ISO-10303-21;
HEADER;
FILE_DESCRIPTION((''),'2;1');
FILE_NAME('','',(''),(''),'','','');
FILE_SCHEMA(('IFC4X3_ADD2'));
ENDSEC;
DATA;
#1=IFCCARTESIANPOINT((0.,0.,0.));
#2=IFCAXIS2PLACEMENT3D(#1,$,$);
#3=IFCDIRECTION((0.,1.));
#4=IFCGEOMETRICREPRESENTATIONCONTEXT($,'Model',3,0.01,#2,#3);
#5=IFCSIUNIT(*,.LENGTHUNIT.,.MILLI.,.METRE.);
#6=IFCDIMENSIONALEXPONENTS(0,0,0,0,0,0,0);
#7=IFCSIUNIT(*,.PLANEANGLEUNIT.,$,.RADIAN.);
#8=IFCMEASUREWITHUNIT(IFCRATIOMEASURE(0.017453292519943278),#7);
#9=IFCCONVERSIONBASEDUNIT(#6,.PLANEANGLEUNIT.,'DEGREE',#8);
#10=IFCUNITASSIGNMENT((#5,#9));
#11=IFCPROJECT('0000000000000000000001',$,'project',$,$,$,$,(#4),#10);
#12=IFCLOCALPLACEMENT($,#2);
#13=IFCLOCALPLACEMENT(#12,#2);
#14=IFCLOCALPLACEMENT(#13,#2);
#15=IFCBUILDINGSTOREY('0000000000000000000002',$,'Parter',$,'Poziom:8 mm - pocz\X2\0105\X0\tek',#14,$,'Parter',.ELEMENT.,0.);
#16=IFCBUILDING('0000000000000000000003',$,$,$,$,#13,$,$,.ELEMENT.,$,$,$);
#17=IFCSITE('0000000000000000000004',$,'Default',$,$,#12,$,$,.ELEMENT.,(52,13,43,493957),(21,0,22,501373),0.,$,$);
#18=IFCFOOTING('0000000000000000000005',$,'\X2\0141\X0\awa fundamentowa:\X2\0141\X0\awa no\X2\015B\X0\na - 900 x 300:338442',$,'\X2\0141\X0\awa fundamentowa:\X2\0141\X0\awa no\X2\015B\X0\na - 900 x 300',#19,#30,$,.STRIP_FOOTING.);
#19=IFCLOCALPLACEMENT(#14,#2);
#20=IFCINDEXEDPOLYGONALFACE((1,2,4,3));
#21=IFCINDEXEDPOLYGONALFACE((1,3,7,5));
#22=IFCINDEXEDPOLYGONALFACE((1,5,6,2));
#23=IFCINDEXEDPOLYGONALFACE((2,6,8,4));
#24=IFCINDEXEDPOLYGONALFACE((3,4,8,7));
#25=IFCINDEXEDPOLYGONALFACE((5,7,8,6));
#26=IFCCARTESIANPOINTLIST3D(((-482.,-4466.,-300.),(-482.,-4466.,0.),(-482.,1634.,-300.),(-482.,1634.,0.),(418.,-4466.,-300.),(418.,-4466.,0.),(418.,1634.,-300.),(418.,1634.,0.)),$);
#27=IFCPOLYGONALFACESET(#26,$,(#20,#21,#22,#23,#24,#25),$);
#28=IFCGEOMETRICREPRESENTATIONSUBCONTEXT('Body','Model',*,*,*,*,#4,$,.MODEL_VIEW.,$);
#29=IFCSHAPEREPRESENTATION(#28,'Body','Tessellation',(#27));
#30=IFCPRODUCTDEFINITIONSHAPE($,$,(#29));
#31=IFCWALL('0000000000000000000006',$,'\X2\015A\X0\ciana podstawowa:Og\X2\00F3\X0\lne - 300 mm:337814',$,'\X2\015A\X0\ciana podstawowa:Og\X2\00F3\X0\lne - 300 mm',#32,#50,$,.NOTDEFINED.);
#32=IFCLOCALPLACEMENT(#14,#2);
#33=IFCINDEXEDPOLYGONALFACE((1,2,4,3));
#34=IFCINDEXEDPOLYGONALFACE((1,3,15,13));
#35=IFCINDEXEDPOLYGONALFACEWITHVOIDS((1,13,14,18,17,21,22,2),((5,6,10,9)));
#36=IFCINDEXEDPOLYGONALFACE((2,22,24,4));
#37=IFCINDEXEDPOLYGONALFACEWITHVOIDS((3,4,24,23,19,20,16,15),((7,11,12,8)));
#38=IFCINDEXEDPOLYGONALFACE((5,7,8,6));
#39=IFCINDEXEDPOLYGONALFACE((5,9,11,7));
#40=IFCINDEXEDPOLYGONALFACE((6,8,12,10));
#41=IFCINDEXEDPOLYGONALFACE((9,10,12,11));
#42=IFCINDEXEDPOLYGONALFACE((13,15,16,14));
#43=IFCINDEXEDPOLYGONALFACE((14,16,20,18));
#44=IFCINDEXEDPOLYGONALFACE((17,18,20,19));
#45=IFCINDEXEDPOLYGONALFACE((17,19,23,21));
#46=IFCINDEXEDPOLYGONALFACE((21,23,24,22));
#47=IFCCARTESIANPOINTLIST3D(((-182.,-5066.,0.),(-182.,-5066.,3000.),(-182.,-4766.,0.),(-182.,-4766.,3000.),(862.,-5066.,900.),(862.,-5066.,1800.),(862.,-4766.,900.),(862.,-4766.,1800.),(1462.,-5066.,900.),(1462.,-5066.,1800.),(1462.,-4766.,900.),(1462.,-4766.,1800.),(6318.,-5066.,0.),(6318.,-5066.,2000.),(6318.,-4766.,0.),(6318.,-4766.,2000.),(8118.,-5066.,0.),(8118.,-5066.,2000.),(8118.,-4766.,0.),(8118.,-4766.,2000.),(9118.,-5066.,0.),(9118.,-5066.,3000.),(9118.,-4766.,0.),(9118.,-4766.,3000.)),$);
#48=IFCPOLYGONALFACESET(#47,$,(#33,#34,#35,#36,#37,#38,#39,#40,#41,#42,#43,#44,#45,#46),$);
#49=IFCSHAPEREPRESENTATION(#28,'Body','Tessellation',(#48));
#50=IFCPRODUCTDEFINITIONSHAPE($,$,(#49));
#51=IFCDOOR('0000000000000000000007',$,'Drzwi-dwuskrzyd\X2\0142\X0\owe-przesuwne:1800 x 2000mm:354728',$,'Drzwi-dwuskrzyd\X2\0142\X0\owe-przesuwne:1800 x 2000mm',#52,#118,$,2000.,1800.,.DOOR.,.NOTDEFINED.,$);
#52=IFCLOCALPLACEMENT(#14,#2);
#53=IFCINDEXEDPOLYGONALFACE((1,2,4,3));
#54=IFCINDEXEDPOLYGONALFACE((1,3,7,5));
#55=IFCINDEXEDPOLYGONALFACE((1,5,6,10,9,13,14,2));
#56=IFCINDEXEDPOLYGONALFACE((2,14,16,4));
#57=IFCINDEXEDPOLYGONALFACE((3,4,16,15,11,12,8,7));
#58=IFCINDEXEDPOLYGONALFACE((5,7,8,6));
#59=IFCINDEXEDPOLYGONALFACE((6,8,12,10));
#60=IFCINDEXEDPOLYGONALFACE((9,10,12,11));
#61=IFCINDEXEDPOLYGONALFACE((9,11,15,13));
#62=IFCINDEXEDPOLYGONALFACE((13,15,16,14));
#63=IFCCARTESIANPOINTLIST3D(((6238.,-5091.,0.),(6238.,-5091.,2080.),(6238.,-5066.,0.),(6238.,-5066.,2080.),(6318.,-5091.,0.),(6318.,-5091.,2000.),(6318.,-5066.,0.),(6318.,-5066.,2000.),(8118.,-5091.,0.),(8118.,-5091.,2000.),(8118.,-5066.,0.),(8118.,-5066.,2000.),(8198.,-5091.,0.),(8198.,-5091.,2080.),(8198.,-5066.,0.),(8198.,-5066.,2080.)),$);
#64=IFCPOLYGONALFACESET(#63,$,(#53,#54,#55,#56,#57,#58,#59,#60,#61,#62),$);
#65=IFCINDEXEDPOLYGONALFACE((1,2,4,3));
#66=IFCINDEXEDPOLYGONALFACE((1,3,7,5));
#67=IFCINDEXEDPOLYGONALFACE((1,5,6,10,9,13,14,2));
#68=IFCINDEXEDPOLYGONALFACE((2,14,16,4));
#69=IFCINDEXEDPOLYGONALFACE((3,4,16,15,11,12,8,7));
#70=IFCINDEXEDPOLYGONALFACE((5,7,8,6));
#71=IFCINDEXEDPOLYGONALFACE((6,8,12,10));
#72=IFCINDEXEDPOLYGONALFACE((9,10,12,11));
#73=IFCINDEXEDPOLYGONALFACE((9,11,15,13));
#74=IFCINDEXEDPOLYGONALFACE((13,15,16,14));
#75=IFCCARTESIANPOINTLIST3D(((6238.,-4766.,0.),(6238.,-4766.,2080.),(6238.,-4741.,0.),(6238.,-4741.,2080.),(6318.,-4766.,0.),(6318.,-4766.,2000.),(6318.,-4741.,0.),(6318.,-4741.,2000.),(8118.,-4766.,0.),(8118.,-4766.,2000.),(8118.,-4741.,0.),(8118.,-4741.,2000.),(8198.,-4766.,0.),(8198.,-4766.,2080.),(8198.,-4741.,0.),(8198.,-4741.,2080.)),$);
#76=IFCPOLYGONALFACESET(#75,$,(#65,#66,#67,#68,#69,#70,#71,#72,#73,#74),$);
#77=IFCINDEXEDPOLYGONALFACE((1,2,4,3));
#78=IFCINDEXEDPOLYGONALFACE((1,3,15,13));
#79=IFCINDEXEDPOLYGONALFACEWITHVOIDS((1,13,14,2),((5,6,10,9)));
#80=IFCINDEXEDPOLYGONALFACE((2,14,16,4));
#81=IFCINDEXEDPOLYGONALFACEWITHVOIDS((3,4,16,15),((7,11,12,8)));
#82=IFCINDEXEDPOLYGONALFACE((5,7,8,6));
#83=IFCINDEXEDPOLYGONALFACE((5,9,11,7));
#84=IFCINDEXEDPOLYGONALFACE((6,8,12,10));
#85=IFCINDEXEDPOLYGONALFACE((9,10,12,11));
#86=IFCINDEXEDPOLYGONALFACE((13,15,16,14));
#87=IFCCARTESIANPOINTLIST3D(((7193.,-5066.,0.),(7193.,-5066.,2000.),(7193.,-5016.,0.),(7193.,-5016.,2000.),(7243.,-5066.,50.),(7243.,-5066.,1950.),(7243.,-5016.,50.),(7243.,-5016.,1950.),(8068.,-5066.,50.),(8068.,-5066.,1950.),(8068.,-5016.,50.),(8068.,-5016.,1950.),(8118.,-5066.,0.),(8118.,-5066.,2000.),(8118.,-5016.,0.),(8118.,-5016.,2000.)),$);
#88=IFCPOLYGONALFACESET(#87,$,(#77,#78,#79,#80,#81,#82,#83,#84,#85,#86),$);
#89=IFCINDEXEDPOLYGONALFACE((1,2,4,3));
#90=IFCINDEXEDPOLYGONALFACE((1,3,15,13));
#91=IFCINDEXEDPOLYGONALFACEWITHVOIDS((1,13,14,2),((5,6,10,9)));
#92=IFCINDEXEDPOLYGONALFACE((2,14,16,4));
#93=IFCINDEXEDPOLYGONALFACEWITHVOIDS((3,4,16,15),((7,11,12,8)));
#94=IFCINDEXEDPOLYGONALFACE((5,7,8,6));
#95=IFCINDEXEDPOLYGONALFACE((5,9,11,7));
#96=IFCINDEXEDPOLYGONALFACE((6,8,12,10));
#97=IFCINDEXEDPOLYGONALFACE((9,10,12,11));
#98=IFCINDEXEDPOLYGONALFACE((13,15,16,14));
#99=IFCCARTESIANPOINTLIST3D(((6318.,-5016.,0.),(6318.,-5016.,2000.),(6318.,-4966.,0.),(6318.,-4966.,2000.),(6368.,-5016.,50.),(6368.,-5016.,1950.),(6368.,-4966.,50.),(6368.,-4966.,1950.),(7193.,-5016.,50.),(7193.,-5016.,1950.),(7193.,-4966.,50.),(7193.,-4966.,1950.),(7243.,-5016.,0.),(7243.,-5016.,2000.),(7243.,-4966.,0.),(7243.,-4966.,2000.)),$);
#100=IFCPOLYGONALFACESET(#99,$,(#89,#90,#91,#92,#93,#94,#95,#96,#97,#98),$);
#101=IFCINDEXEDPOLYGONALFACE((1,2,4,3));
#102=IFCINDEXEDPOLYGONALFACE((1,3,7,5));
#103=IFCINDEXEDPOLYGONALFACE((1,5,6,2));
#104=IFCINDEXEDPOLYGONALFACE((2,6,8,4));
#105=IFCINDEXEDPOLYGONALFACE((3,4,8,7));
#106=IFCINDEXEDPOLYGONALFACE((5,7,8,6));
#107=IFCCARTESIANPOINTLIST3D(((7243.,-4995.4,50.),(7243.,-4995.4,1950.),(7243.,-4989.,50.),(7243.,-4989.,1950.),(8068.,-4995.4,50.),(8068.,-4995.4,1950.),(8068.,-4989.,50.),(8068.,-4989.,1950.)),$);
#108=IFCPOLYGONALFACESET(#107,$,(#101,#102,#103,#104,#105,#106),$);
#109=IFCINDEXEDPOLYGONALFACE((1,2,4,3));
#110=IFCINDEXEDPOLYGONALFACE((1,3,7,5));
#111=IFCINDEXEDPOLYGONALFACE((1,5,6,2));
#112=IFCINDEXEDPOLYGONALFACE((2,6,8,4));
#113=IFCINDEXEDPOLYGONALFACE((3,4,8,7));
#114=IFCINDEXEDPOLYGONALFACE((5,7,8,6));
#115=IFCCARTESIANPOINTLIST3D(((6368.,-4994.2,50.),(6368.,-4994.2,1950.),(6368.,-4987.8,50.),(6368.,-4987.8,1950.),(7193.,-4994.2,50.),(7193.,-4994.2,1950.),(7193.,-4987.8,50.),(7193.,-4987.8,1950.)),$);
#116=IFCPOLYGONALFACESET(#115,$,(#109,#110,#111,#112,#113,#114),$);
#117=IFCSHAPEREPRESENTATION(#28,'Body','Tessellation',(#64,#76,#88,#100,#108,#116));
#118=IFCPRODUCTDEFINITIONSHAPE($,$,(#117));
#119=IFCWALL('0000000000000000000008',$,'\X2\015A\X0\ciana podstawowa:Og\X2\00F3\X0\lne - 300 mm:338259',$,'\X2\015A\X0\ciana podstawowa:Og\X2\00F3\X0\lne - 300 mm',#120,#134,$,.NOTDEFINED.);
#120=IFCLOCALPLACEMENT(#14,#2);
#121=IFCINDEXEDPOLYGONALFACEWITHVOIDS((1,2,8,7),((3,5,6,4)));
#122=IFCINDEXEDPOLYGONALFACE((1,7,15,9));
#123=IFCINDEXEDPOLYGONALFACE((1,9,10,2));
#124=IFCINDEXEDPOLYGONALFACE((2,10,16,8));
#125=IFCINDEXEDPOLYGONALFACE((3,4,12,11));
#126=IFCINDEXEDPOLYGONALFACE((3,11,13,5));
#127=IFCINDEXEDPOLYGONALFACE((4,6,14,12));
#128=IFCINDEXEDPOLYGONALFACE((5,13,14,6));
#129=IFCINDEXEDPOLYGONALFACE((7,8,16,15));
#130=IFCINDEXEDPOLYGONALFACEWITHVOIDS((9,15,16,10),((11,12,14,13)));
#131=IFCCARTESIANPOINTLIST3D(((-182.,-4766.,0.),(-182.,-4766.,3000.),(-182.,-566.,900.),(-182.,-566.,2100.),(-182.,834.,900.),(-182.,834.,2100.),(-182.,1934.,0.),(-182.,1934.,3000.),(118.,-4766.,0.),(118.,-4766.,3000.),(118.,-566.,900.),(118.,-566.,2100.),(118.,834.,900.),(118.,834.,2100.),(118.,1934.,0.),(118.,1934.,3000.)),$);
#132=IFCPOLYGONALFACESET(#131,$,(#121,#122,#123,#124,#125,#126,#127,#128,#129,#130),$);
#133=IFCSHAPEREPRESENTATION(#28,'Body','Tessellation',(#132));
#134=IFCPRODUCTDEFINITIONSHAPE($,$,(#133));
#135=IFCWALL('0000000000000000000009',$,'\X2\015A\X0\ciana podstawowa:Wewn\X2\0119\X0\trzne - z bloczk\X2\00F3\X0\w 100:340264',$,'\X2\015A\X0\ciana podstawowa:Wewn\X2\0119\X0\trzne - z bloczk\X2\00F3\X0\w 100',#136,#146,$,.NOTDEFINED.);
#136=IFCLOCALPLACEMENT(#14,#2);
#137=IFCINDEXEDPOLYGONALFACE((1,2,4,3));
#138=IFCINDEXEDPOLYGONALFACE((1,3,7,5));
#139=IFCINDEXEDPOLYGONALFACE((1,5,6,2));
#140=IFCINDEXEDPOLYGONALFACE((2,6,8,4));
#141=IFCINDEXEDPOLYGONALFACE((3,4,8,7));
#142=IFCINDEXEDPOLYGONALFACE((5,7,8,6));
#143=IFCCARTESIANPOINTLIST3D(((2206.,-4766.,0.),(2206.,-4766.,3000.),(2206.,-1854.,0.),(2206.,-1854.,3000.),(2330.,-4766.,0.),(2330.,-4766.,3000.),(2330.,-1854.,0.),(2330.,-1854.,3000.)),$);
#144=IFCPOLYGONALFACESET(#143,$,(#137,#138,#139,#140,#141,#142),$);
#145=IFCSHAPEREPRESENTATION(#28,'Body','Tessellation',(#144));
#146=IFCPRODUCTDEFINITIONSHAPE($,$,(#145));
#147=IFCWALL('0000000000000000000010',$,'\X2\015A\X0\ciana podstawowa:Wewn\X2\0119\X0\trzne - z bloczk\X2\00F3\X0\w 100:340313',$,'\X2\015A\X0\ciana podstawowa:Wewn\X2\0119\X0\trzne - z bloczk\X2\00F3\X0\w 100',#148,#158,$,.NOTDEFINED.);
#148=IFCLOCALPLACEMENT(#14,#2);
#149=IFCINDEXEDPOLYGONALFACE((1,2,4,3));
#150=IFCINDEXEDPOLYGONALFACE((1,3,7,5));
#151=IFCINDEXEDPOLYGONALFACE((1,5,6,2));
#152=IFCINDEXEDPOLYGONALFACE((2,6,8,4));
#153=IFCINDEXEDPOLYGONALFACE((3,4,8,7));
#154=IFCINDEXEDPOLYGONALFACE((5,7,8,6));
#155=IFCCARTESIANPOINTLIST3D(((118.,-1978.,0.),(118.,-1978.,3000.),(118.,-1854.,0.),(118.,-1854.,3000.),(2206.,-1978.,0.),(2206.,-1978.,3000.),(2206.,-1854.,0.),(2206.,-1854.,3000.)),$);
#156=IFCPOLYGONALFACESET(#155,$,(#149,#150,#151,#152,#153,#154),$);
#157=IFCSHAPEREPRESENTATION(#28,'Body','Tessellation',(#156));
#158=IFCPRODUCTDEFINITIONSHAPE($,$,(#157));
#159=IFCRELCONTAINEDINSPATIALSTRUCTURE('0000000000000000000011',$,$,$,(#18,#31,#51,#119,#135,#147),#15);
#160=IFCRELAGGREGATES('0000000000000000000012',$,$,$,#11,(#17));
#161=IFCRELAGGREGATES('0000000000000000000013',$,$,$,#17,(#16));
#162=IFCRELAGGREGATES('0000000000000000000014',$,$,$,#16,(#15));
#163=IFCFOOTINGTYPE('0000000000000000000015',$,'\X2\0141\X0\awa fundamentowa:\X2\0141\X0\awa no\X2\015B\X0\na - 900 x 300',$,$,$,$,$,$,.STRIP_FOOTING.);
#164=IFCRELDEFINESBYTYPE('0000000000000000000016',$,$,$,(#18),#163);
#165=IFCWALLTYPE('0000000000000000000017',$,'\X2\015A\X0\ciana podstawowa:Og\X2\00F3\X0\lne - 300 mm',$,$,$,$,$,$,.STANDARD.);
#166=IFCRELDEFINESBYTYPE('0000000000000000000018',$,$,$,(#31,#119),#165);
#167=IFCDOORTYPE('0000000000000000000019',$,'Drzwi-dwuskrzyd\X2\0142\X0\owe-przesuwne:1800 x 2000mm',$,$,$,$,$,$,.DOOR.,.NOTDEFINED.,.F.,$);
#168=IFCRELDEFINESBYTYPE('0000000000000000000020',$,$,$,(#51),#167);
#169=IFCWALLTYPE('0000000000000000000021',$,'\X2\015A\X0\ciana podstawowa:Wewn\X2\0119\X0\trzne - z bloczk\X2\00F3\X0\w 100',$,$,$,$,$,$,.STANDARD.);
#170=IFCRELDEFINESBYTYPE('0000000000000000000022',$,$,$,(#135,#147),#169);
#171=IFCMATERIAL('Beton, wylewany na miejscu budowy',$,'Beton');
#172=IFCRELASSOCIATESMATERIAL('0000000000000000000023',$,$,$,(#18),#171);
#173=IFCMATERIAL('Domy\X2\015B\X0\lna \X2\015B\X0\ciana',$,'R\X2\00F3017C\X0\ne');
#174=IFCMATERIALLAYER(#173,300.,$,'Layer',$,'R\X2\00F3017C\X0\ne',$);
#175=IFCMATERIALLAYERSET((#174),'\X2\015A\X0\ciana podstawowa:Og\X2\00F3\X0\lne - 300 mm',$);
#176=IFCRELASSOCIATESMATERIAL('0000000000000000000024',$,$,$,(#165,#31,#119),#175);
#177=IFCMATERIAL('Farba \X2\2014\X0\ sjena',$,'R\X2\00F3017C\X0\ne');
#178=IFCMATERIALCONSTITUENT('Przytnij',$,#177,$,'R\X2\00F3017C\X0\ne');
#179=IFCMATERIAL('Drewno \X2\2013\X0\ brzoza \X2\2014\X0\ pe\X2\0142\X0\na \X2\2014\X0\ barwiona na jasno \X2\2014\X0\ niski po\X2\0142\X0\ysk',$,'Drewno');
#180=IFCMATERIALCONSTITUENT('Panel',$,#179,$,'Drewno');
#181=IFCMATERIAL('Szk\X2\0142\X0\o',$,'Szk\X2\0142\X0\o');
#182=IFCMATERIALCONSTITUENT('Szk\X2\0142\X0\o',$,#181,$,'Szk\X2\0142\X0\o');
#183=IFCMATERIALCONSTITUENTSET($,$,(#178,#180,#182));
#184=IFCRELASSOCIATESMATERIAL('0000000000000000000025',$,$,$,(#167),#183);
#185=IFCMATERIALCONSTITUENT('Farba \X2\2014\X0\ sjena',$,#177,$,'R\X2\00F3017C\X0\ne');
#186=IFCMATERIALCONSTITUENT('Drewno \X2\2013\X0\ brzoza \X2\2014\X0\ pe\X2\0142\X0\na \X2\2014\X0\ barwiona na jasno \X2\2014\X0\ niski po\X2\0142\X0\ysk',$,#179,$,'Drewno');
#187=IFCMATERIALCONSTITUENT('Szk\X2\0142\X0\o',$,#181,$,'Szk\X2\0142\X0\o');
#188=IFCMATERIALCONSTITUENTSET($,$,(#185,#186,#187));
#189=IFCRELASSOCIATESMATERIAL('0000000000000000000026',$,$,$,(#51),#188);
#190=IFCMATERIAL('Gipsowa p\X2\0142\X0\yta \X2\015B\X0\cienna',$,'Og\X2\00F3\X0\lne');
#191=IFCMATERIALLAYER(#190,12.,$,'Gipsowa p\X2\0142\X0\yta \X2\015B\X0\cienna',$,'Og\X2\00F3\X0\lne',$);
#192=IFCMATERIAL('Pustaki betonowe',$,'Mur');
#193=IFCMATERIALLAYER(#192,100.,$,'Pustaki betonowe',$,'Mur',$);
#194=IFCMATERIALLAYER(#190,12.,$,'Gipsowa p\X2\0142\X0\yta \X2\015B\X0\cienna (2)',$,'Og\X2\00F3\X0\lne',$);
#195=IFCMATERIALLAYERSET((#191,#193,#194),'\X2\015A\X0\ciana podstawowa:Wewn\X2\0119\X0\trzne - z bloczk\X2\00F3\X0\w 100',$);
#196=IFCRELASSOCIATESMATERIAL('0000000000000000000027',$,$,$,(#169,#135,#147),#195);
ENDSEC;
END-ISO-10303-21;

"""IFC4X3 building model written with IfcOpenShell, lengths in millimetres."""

from ifc_helpers import new_model, entity, si_unit, converted_unit, direction, frame, frame_2d, origin, place, context, subcontext, project, spatial, polyline, rectangle, outline, extrude, source, transform, mapped, material, layer, layer_set, constituent, constituent_set, type_object, type_shapes, element, fill, save


model = new_model("IFC4X3")

# Units and contexts
model_context = context("Model", 3, precision=0.01, world=origin(), true_north=direction((0.0, 1.0)))
body_context = subcontext(model_context, "Body", "Model", "MODEL_VIEW")
ifc_project = project(units=[si_unit("LENGTHUNIT", "METRE", prefix="MILLI"), converted_unit("PLANEANGLEUNIT", "DEGREE", entity("IfcRatioMeasure", 0.017453292519943278), si_unit("PLANEANGLEUNIT", "RADIAN"), dimensions=[0, 0, 0, 0, 0, 0, 0])], contexts=[model_context])

# Site, building, storey
site_placement = place(None, origin())
site = spatial("IfcSite", under=ifc_project, at=site_placement, Name="Default", CompositionType="ELEMENT", RefLatitude=(52, 13, 43, 493957), RefLongitude=(21, 0, 22, 501373), RefElevation=0.0)
building_placement = place(site_placement, origin())
building = spatial("IfcBuilding", under=site, at=building_placement, CompositionType="ELEMENT")
storey_placement = place(building_placement, origin())
storey = spatial("IfcBuildingStorey", under=building, at=storey_placement, Name="Parter", ObjectType="Poziom:8 mm - początek", LongName="Parter", CompositionType="ELEMENT", Elevation=0.0)

# Footing
ifc_material_1 = material(Name="Beton, wylewany na miejscu budowy", Category="Beton")
footing_type = type_object("IfcFootingType", Name="Ława fundamentowa:Ława nośna - 900 x 300", PredefinedType="STRIP_FOOTING")
footing_1_placement = place(storey_placement, origin())
element("IfcFooting", 1, at=footing_1_placement, inside=storey, type_object=footing_type, material=ifc_material_1, Name="Ława fundamentowa:Ława nośna - 900 x 300:338442", ObjectType="Ława fundamentowa:Ława nośna - 900 x 300", PredefinedType="STRIP_FOOTING", context=body_context, shape_type="SweptSolid", body=[
    extrude(rectangle(XDim=6100.0, YDim=900.0, at=frame_2d((0.0, 0.0), x_axis=(1.0, 0.0))), frame((-32.0, -1416.0, -300.0), z_axis=(0.0, 0.0, 1.0), x_axis=(0.0, 1.0, 0.0)), (0.0, 0.0, 1.0), 300.0),
])

# Wall, openings, door
ifc_material_2 = material(Name="Domyślna ściana", Category="Różne")
ifc_layer_1 = layer(ifc_material_2, 300.0, Name="Layer", Category="Różne")
ifc_layer_set_1 = layer_set([ifc_layer_1], Name="Ściana podstawowa:Ogólne - 300 mm")
wall_type_1 = type_object("IfcWallType", Name="Ściana podstawowa:Ogólne - 300 mm", PredefinedType="STANDARD", material=ifc_layer_set_1)
wall_1_placement = place(storey_placement, frame((-182.0, -4916.0, 0.0)))
wall_1 = element("IfcWall", 2, at=wall_1_placement, inside=storey, type_object=wall_type_1, material=ifc_layer_set_1, Name="Ściana podstawowa:Ogólne - 300 mm:337814", ObjectType="Ściana podstawowa:Ogólne - 300 mm", PredefinedType="NOTDEFINED", context=body_context, shape_type="SweptSolid", body=[
    extrude(rectangle(XDim=9300.0, YDim=300.0, at=frame_2d((4650.0, 0.0), x_axis=(1.0, 0.0))), origin(), (0.0, 0.0, 1.0), 3000.0),
])
opening_1_placement = place(wall_1_placement, frame((8300.0, 150.0, 0.0)))
opening_1 = element("IfcOpeningElement", 3, at=opening_1_placement, cuts=wall_1, PredefinedType="OPENING", context=body_context, shape_type="SweptSolid", body=[
    extrude(rectangle(XDim=2000.0, YDim=1800.0, at=frame_2d((1000.0, 900.0), x_axis=(-1.0, 0.0))), frame((0.0, 0.0, 0.0), z_axis=(0.0, -1.0, 0.0), x_axis=(0.0, 0.0, 1.0)), (0.0, 0.0, 1.0), 300.0),
])
opening_2_placement = place(wall_1_placement, frame((1644.0, 150.0, 900.0)))
element("IfcOpeningElement", 4, at=opening_2_placement, cuts=wall_1, PredefinedType="OPENING", context=body_context, shape_type="SweptSolid", body=[
    extrude(rectangle(XDim=900.0, YDim=600.0, at=frame_2d((450.0, 300.0), x_axis=(-1.0, 0.0))), frame((0.0, 0.0, 0.0), z_axis=(0.0, -1.0, 0.0), x_axis=(0.0, 0.0, 1.0)), (0.0, 0.0, 1.0), 300.0),
])
ifc_material_3 = material(Name="Farba — sjena", Category="Różne")
ifc_constituent_1 = constituent(ifc_material_3, Name="Farba — sjena", Category="Różne")
ifc_material_4 = material(Name="Drewno – brzoza — pełna — barwiona na jasno — niski połysk", Category="Drewno")
ifc_constituent_2 = constituent(ifc_material_4, Name="Drewno – brzoza — pełna — barwiona na jasno — niski połysk", Category="Drewno")
ifc_material_5 = material(Name="Szkło", Category="Szkło")
ifc_constituent_3 = constituent(ifc_material_5, Name="Szkło", Category="Szkło")
ifc_constituent_set_1 = constituent_set(constituents=[ifc_constituent_1, ifc_constituent_2, ifc_constituent_3])
ifc_constituent_4 = constituent(ifc_material_3, Name="Przytnij", Category="Różne")
ifc_constituent_5 = constituent(ifc_material_4, Name="Panel", Category="Drewno")
ifc_constituent_6 = constituent(ifc_material_5, Name="Szkło", Category="Szkło")
ifc_constituent_set_2 = constituent_set(constituents=[ifc_constituent_4, ifc_constituent_5, ifc_constituent_6])
door_type = type_object("IfcDoorType", Name="Drzwi-dwuskrzydłowe-przesuwne:1800 x 2000mm", OperationType="NOTDEFINED", ParameterTakesPrecedence=False, PredefinedType="DOOR", material=ifc_constituent_set_2)
shared_shape_1 = source(origin(), body_context, "Body", "SweptSolid", [
    extrude(outline(polyline([(-980.0, -1020.0), (-900.0, -1020.0), (-900.0, 980.0), (900.0, 980.0), (900.0, -1020.0), (980.0, -1020.0), (980.0, 1060.0), (-980.0, 1060.0), (-980.0, -1020.0)])), frame((900.0, 300.0, 1020.0), z_axis=(0.0, 1.0, 0.0), x_axis=(-1.0, 0.0, 0.0)), (0.0, 0.0, 1.0), 25.0),
    extrude(outline(polyline([(-1020.0, -980.0), (1060.0, -980.0), (1060.0, 980.0), (-1020.0, 980.0), (-1020.0, 900.0), (980.0, 900.0), (980.0, -900.0), (-1020.0, -900.0), (-1020.0, -980.0)])), frame((900.0, -25.0, 1020.0), z_axis=(0.0, 1.0, 0.0), x_axis=(0.0, 0.0, 1.0)), (0.0, 0.0, 1.0), 25.0),
    extrude(outline(polyline([(-1000.0, -462.5), (1000.0, -462.5), (1000.0, 462.5), (-1000.0, 462.5), (-1000.0, -462.5)]), holes=[polyline([(-950.0, -412.5), (-950.0, 412.5), (950.0, 412.5), (950.0, -412.5), (-950.0, -412.5)])]), frame((462.5, 250.0, 1000.0), z_axis=(0.0, 1.0, 0.0), x_axis=(0.0, 0.0, -1.0)), (0.0, 0.0, 1.0), 50.0),
    extrude(outline(polyline([(-462.5, -1000.0), (462.5, -1000.0), (462.5, 1000.0), (-462.5, 1000.0), (-462.5, -1000.0)]), holes=[polyline([(-412.5, -950.0), (-412.5, 950.0), (412.5, 950.0), (412.5, -950.0), (-412.5, -950.0)])]), frame((1337.5, 200.0, 1000.0), z_axis=(0.0, 1.0, 0.0), x_axis=(1.0, 0.0, 0.0)), (0.0, 0.0, 1.0), 50.0),
    extrude(rectangle(XDim=6.4, YDim=825.0, at=frame_2d((0.0, 0.0), x_axis=(1.0, 0.0))), frame((462.5, 226.2, 50.0), z_axis=(0.0, 0.0, 1.0), x_axis=(0.0, 1.0, 0.0)), (0.0, 0.0, 1.0), 1900.0),
    extrude(rectangle(XDim=6.3, YDim=825.0, at=frame_2d((0.0, 0.0), x_axis=(1.0, 0.0))), frame((1337.5, 225.0, 50.0), z_axis=(0.0, 0.0, 1.0), x_axis=(0.0, -1.0, 0.0)), (0.0, 0.0, 1.0), 1900.0),
])
type_shapes(door_type, [shared_shape_1])
door_placement = place(opening_1_placement, frame((0.0, 0.0, 0.0), z_axis=(0.0, 0.0, 1.0), x_axis=(-1.0, 0.0, 0.0)))
door = element("IfcDoor", 5, at=door_placement, inside=storey, type_object=door_type, material=ifc_constituent_set_1, Name="Drzwi-dwuskrzydłowe-przesuwne:1800 x 2000mm:354728", ObjectType="Drzwi-dwuskrzydłowe-przesuwne:1800 x 2000mm", OperationType="NOTDEFINED", OverallHeight=2000.0, OverallWidth=1800.0, PredefinedType="DOOR", context=body_context, shape_type="MappedRepresentation", body=[
    mapped(shared_shape_1, transform((0.0, 0.0, 0.0), scale=1.0)),
])
fill(opening_1, door)

# Wall, opening
wall_2_placement = place(storey_placement, frame((-32.0, 1934.0, 0.0), z_axis=(0.0, 0.0, 1.0), x_axis=(0.0, -1.0, 0.0)))
wall_2 = element("IfcWall", 6, at=wall_2_placement, inside=storey, type_object=wall_type_1, material=ifc_layer_set_1, Name="Ściana podstawowa:Ogólne - 300 mm:338259", ObjectType="Ściana podstawowa:Ogólne - 300 mm", PredefinedType="NOTDEFINED", context=body_context, shape_type="SweptSolid", body=[
    extrude(rectangle(XDim=6700.0, YDim=300.0, at=frame_2d((3350.0, 0.0), x_axis=(-1.0, 0.0))), origin(), (0.0, 0.0, 1.0), 3000.0),
])
opening_3_placement = place(wall_2_placement, frame((2500.0, 150.0, 900.0)))
element("IfcOpeningElement", 7, at=opening_3_placement, cuts=wall_2, PredefinedType="OPENING", context=body_context, shape_type="SweptSolid", body=[
    extrude(rectangle(XDim=1200.0, YDim=1400.0, at=frame_2d((600.0, 700.0), x_axis=(-1.0, 0.0))), frame((0.0, 0.0, 0.0), z_axis=(0.0, -1.0, 0.0), x_axis=(0.0, 0.0, 1.0)), (0.0, 0.0, 1.0), 300.0),
])

# Walls
ifc_material_6 = material(Name="Gipsowa płyta ścienna", Category="Ogólne")
ifc_layer_2 = layer(ifc_material_6, 12.0, Name="Gipsowa płyta ścienna", Category="Ogólne")
ifc_material_7 = material(Name="Pustaki betonowe", Category="Mur")
ifc_layer_3 = layer(ifc_material_7, 100.0, Name="Pustaki betonowe", Category="Mur")
ifc_layer_4 = layer(ifc_material_6, 12.0, Name="Gipsowa płyta ścienna (2)", Category="Ogólne")
ifc_layer_set_2 = layer_set([ifc_layer_2, ifc_layer_3, ifc_layer_4], Name="Ściana podstawowa:Wewnętrzne - z bloczków 100")
wall_type_2 = type_object("IfcWallType", Name="Ściana podstawowa:Wewnętrzne - z bloczków 100", PredefinedType="STANDARD", material=ifc_layer_set_2)
wall_3_placement = place(storey_placement, frame((2268.0, -4766.0, 0.0), z_axis=(0.0, 0.0, 1.0), x_axis=(0.0, 1.0, 0.0)))
element("IfcWall", 8, at=wall_3_placement, inside=storey, type_object=wall_type_2, material=ifc_layer_set_2, Name="Ściana podstawowa:Wewnętrzne - z bloczków 100:340264", ObjectType="Ściana podstawowa:Wewnętrzne - z bloczków 100", PredefinedType="NOTDEFINED", context=body_context, shape_type="SweptSolid", body=[
    extrude(rectangle(XDim=2912.0, YDim=124.0, at=frame_2d((1456.0, 0.0), x_axis=(-1.0, 0.0))), origin(), (0.0, 0.0, 1.0), 3000.0),
])
wall_4_placement = place(storey_placement, frame((2206.0, -1916.0, 0.0), z_axis=(0.0, 0.0, 1.0), x_axis=(-1.0, 0.0, 0.0)))
element("IfcWall", 9, at=wall_4_placement, inside=storey, type_object=wall_type_2, material=ifc_layer_set_2, Name="Ściana podstawowa:Wewnętrzne - z bloczków 100:340313", ObjectType="Ściana podstawowa:Wewnętrzne - z bloczków 100", PredefinedType="NOTDEFINED", context=body_context, shape_type="SweptSolid", body=[
    extrude(rectangle(XDim=2088.0, YDim=124.0, at=frame_2d((1044.0, 0.0), x_axis=(-1.0, 0.0))), origin(), (0.0, 0.0, 1.0), 3000.0),
])

save(model, "model.ifc")
